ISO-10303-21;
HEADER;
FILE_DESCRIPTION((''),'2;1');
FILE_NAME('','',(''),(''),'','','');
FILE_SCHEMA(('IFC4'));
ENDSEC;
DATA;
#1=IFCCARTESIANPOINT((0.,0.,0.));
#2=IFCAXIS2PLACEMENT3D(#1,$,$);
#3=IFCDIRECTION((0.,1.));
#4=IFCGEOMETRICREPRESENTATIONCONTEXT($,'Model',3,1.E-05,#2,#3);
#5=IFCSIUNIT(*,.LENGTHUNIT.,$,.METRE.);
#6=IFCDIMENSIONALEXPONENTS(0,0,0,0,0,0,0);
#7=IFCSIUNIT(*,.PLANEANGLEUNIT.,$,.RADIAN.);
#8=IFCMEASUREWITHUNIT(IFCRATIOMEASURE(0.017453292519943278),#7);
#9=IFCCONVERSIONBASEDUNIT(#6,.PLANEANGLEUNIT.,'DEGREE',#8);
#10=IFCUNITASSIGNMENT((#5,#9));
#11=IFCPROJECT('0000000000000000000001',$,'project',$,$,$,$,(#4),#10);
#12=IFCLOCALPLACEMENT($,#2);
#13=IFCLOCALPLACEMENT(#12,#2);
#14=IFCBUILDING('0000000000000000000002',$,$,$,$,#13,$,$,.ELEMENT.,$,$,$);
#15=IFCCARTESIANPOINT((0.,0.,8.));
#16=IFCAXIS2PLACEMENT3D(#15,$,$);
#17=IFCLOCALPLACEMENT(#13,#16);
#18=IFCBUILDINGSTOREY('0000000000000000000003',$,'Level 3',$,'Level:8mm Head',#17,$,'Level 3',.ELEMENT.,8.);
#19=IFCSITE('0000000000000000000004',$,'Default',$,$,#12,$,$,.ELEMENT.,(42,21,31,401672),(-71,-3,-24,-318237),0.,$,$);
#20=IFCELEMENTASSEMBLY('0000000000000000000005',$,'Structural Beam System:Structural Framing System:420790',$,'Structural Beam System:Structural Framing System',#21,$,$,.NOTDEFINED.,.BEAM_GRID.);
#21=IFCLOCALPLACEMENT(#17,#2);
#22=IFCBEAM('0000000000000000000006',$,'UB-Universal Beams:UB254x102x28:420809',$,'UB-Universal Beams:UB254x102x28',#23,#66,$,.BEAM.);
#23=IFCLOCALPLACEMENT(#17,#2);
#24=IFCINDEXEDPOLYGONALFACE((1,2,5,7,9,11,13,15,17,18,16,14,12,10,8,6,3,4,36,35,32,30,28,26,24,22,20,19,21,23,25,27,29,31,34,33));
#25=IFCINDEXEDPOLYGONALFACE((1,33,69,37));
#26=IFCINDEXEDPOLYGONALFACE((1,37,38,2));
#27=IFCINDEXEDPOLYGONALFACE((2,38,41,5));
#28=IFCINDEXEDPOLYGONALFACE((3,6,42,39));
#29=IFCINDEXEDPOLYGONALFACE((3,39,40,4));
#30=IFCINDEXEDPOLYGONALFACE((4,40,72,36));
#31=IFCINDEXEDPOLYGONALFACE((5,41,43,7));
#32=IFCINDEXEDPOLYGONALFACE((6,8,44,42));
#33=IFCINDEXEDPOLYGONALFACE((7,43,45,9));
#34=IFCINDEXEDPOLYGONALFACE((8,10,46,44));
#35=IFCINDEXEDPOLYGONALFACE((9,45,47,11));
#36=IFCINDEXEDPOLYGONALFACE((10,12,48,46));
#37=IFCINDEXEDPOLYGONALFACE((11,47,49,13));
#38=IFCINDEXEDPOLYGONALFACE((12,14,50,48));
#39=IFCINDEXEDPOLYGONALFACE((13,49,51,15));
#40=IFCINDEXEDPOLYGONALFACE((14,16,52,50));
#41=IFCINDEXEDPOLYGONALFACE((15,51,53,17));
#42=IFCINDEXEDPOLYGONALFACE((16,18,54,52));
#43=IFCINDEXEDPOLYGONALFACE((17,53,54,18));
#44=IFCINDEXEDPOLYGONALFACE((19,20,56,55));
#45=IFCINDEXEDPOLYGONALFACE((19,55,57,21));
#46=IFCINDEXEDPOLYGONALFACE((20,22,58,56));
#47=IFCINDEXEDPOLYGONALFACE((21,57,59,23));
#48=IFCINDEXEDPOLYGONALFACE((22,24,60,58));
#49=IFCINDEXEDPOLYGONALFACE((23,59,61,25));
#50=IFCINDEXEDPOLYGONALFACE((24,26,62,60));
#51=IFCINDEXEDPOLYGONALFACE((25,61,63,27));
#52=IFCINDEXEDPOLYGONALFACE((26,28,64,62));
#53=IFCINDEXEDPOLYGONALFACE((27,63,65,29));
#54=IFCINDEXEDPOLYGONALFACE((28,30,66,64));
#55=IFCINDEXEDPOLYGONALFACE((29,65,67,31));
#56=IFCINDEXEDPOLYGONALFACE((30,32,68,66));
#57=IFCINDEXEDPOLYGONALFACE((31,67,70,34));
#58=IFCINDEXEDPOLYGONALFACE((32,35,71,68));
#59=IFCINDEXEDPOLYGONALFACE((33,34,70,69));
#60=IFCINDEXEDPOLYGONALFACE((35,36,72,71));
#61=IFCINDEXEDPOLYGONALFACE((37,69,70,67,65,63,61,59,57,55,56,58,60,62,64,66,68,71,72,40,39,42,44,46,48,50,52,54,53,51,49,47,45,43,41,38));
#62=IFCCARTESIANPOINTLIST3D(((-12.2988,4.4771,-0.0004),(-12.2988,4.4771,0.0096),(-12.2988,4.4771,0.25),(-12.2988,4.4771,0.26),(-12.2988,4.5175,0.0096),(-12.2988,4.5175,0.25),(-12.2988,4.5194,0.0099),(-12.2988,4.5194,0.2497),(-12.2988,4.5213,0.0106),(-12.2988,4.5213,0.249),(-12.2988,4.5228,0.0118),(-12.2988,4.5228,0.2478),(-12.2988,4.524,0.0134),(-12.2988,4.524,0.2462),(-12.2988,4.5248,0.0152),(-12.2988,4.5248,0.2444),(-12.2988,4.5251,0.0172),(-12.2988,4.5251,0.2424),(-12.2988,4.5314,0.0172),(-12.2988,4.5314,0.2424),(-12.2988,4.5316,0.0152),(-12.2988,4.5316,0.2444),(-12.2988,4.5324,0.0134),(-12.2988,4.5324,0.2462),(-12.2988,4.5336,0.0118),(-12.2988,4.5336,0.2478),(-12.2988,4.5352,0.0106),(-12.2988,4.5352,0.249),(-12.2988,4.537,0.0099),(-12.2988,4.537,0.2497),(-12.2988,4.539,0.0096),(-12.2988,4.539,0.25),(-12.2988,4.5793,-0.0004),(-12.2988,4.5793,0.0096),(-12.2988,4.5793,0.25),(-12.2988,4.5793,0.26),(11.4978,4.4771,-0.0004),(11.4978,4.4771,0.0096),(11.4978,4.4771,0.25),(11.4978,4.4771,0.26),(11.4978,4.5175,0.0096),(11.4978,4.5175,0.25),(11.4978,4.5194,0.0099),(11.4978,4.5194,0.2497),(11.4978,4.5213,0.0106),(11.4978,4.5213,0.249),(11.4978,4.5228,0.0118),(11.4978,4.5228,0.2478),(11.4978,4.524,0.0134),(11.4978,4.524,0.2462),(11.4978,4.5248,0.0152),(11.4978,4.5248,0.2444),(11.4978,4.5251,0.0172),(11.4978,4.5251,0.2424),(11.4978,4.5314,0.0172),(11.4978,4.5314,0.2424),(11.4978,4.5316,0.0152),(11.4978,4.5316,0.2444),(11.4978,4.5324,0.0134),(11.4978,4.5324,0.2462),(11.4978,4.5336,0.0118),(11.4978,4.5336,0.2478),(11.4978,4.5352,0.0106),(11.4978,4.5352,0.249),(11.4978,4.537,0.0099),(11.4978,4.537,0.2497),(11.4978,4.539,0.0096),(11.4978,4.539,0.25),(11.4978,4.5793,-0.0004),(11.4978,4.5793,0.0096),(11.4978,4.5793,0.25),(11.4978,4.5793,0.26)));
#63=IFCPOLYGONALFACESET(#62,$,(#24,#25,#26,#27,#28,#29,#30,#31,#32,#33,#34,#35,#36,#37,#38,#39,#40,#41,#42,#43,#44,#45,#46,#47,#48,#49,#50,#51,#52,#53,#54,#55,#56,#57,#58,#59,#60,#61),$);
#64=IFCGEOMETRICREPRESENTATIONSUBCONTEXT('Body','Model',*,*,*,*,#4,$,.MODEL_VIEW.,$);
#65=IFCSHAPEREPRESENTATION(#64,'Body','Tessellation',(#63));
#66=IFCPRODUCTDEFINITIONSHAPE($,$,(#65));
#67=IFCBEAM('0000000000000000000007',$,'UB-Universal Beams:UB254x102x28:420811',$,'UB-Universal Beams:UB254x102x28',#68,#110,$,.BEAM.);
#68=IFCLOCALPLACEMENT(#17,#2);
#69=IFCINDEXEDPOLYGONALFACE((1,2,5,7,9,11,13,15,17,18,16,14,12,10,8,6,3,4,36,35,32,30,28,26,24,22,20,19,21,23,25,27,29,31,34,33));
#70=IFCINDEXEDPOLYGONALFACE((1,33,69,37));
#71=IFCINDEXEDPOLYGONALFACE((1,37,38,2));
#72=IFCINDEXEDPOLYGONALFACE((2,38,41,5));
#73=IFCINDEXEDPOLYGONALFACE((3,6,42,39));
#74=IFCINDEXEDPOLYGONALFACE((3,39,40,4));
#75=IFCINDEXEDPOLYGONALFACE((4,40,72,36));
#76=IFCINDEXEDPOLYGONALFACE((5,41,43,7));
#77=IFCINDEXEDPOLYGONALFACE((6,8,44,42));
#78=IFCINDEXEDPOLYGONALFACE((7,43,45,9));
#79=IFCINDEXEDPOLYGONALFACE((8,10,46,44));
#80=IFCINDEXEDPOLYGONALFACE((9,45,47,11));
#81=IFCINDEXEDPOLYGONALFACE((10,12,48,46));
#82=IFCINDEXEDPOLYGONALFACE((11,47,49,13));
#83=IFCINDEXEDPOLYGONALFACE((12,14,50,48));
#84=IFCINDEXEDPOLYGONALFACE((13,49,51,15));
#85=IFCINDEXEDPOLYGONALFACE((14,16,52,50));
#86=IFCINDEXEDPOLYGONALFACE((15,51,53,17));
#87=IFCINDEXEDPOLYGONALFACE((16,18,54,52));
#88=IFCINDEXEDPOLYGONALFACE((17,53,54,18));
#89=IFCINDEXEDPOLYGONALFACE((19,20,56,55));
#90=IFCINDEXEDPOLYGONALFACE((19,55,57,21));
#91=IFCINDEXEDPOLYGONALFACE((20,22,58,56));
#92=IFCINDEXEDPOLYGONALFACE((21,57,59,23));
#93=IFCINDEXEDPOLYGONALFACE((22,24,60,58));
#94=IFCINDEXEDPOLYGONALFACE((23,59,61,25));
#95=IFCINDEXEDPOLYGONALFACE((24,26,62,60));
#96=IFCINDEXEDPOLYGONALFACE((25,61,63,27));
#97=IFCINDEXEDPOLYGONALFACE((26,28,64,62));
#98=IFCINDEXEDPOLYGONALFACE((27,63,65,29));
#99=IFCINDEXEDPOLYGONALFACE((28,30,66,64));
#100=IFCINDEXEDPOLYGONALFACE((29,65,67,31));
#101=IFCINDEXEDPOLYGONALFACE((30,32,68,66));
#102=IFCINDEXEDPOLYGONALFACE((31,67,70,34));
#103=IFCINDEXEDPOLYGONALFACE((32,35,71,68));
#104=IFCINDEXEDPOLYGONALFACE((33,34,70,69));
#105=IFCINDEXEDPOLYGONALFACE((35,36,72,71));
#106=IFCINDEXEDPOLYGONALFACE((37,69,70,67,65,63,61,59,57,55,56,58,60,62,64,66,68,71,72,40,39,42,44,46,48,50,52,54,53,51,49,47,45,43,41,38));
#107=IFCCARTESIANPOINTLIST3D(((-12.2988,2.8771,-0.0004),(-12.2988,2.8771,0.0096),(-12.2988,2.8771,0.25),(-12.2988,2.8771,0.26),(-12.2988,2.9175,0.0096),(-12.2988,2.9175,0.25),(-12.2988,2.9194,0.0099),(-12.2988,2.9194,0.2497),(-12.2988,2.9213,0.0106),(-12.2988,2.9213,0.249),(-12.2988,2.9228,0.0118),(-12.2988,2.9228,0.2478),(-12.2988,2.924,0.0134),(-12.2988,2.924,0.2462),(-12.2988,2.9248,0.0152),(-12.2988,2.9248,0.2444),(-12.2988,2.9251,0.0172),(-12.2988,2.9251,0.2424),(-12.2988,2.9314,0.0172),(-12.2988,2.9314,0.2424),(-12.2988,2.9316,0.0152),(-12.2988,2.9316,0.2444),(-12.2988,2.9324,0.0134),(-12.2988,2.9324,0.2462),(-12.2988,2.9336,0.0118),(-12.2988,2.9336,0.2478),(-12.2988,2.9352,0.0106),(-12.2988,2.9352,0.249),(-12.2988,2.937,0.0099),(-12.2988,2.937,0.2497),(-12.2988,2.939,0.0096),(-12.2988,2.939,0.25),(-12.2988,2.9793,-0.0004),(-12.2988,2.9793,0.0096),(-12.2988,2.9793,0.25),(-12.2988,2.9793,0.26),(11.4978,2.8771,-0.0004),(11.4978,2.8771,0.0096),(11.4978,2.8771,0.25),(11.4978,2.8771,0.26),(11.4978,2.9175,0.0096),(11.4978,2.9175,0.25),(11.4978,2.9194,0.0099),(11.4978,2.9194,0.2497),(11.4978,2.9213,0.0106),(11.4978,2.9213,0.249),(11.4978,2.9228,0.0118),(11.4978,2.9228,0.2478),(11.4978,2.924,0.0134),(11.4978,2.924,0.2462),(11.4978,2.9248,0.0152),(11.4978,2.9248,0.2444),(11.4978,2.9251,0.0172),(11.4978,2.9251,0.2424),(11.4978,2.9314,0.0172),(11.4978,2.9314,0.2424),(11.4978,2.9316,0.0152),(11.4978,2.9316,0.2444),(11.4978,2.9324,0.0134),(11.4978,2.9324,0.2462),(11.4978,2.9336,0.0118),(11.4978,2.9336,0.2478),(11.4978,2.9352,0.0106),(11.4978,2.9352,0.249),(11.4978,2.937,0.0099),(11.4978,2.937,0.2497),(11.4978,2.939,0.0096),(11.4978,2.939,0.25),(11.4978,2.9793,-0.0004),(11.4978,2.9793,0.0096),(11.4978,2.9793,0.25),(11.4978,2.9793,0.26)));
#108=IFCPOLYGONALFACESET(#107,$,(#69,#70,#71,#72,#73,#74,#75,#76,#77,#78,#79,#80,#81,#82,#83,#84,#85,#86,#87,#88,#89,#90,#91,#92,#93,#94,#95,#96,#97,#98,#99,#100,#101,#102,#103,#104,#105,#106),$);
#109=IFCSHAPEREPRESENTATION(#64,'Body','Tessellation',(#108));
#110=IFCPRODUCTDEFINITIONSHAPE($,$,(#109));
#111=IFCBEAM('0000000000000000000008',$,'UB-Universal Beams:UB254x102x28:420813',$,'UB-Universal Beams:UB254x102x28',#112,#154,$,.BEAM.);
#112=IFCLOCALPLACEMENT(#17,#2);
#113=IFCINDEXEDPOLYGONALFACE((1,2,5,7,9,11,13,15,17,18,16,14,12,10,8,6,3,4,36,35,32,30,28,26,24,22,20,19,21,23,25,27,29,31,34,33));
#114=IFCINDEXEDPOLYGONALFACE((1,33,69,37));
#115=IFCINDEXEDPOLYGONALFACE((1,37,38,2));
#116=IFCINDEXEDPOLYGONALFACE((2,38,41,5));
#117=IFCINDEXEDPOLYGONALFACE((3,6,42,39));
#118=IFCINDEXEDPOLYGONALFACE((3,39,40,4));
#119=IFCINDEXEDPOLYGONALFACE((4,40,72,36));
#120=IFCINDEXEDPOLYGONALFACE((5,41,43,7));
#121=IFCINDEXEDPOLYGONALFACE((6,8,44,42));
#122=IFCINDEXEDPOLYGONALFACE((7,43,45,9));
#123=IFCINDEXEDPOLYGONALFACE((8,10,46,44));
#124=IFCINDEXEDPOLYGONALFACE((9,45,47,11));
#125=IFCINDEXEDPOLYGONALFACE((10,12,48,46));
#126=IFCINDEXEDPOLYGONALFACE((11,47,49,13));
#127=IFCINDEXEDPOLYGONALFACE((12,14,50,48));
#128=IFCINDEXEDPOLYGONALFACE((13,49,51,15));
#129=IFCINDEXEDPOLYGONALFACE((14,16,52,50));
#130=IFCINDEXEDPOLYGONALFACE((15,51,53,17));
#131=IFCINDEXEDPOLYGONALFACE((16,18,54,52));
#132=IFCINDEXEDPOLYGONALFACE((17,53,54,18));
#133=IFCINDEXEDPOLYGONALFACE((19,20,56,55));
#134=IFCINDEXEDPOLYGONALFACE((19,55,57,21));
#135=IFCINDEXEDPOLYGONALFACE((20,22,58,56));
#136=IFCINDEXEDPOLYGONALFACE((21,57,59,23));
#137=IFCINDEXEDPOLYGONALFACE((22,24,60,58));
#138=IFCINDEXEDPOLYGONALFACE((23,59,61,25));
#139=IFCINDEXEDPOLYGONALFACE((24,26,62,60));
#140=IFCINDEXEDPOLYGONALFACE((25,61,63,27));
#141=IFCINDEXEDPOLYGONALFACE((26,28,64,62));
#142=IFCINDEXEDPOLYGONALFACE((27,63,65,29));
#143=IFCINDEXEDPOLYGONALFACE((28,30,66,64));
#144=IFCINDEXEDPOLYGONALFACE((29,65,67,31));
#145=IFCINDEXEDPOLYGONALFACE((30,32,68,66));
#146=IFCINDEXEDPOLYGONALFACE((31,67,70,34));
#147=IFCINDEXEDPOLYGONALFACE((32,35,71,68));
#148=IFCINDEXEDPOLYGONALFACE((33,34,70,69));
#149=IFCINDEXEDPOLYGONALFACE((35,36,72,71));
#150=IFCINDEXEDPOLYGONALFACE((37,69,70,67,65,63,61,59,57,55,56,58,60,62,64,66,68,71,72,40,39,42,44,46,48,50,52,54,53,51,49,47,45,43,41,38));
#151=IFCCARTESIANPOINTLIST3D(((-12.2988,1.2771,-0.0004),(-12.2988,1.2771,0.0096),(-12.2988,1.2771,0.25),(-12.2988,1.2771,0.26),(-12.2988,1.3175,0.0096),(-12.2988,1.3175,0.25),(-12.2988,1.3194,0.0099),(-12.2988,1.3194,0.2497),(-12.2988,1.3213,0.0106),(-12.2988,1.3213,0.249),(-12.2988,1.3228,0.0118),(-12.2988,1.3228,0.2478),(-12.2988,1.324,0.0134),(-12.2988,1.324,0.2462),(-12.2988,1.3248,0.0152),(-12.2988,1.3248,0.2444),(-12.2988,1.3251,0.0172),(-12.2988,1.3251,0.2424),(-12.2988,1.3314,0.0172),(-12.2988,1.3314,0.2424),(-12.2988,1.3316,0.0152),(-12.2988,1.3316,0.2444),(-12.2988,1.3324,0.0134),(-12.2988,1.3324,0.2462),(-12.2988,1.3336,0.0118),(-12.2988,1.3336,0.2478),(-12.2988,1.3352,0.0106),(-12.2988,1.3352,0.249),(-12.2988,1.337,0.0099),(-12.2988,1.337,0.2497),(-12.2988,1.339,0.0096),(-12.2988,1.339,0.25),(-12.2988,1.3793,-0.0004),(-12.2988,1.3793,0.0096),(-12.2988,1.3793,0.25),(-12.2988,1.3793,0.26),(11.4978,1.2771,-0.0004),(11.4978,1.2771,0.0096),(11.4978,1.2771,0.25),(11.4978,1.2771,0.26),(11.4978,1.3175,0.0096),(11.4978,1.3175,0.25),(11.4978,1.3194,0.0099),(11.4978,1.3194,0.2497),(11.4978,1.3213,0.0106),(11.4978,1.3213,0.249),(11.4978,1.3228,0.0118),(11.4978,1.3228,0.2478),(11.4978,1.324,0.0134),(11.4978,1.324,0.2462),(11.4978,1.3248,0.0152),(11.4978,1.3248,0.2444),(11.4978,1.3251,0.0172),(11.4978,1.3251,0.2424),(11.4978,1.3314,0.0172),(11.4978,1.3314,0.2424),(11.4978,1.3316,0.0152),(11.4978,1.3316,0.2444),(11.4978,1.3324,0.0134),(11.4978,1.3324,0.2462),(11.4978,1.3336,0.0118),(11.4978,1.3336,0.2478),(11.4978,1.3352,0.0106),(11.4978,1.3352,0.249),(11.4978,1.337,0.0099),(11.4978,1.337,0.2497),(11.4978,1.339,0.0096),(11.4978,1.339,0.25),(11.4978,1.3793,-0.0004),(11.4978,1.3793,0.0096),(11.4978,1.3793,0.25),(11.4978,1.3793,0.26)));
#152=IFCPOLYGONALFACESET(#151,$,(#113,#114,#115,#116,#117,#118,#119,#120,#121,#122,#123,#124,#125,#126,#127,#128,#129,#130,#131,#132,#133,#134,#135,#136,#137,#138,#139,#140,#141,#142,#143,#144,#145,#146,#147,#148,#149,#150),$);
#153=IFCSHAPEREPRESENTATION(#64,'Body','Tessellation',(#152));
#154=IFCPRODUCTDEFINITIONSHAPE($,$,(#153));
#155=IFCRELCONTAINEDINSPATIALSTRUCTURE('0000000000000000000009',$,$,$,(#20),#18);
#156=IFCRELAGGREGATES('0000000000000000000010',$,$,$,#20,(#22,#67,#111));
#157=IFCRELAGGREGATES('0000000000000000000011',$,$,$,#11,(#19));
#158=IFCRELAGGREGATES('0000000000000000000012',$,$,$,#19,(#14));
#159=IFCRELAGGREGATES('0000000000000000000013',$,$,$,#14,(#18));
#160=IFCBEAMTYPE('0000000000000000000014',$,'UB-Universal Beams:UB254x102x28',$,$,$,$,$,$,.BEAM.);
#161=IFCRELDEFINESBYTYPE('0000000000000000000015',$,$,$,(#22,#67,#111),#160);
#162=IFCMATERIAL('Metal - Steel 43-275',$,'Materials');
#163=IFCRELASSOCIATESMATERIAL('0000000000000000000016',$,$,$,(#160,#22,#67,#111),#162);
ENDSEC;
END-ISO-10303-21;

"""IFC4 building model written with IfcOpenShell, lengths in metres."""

from ifc_helpers import new_model, entity, si_unit, converted_unit, direction, frame, origin, place, context, subcontext, project, spatial, line, arc, indexed_curve, outline, extrude, source, transform, mapped, material, type_object, type_shapes, element, aggregate, save


model = new_model("IFC4")

# Units and contexts
model_context = context("Model", 3, precision=1e-05, world=origin(), true_north=direction((0.0, 1.0)))
body_context = subcontext(model_context, "Body", "Model", "MODEL_VIEW")
ifc_project = project(units=[si_unit("LENGTHUNIT", "METRE"), converted_unit("PLANEANGLEUNIT", "DEGREE", entity("IfcRatioMeasure", 0.017453292519943278), si_unit("PLANEANGLEUNIT", "RADIAN"), dimensions=[0, 0, 0, 0, 0, 0, 0])], contexts=[model_context])

# Site, building, storey
site_placement = place(None, origin())
site = spatial("IfcSite", under=ifc_project, at=site_placement, Name="Default", CompositionType="ELEMENT", RefLatitude=(42, 21, 31, 401672), RefLongitude=(-71, -3, -24, -318237), RefElevation=0.0)
building_placement = place(site_placement, origin())
building = spatial("IfcBuilding", under=site, at=building_placement, CompositionType="ELEMENT")
storey_placement = place(building_placement, frame((0.0, 0.0, 8.0)))
storey = spatial("IfcBuildingStorey", under=building, at=storey_placement, Name="Level 3", ObjectType="Level:8mm Head", LongName="Level 3", CompositionType="ELEMENT", Elevation=8.0)

# Shared definitions
ifc_material_1 = material(Name="Metal - Steel 43-275", Category="Materials")

# Element assembly, beams
assembly_placement = place(storey_placement, origin())
assembly = element("IfcElementAssembly", 1, at=assembly_placement, inside=storey, Name="Structural Beam System:Structural Framing System:420790", ObjectType="Structural Beam System:Structural Framing System", AssemblyPlace="NOTDEFINED", PredefinedType="BEAM_GRID")
beam_type_1 = type_object("IfcBeamType", Name="UB-Universal Beams:UB254x102x28", PredefinedType="BEAM", material=ifc_material_1)
shared_shape_1 = source(origin(), body_context, "Body", "SweptSolid", [
    extrude(outline(indexed_curve([(-0.1302, -0.0511), (-0.1202, -0.0511), (-0.1202, -0.0107), (-0.118, -0.0054), (-0.1126, -0.0031), (0.1126, -0.0031), (0.118, -0.0054), (0.1202, -0.0107), (0.1202, -0.0511), (0.1302, -0.0511), (0.1302, 0.0511), (0.1202, 0.0511), (0.1202, 0.0108), (0.118, 0.0054), (0.1126, 0.0032), (-0.1126, 0.0032), (-0.118, 0.0054), (-0.1202, 0.0108), (-0.1202, 0.0511), (-0.1302, 0.0511)], segments=[line(1, 2, 3), arc(3, 4, 5), line(5, 6), arc(6, 7, 8), line(8, 9, 10, 11, 12, 13), arc(13, 14, 15), line(15, 16), arc(16, 17, 18), line(18, 19, 20, 1)], self_intersect=False)), frame((-11.8983, 0.0, 0.0), z_axis=(1.0, 0.0, 0.0), x_axis=(0.0, 0.0, -1.0)), (0.0, 0.0, 1.0), 23.7966),
])
type_shapes(beam_type_1, [shared_shape_1])
beam_1_placement = place(assembly_placement, frame((-0.4005, 4.5282, 0.1298)))
beam_1 = element("IfcBeam", 2, at=beam_1_placement, type_object=beam_type_1, material=ifc_material_1, Name="UB-Universal Beams:UB254x102x28:420809", ObjectType="UB-Universal Beams:UB254x102x28", PredefinedType="BEAM", context=body_context, shape_type="MappedRepresentation", body=[
    mapped(shared_shape_1, transform((0.0, 0.0, 0.0), scale=1.0)),
])
beam_2_placement = place(assembly_placement, frame((-0.4005, 2.9282, 0.1298)))
beam_2 = element("IfcBeam", 3, at=beam_2_placement, type_object=beam_type_1, material=ifc_material_1, Name="UB-Universal Beams:UB254x102x28:420811", ObjectType="UB-Universal Beams:UB254x102x28", PredefinedType="BEAM", context=body_context, shape_type="MappedRepresentation", body=[
    mapped(shared_shape_1, transform((0.0, 0.0, 0.0), scale=1.0)),
])
beam_3_placement = place(assembly_placement, frame((-0.4005, 1.3282, 0.1298)))
beam_3 = element("IfcBeam", 4, at=beam_3_placement, type_object=beam_type_1, material=ifc_material_1, Name="UB-Universal Beams:UB254x102x28:420813", ObjectType="UB-Universal Beams:UB254x102x28", PredefinedType="BEAM", context=body_context, shape_type="MappedRepresentation", body=[
    mapped(shared_shape_1, transform((0.0, 0.0, 0.0), scale=1.0)),
])
aggregate(assembly, [beam_1, beam_2, beam_3])

save(model, "model.ifc")
